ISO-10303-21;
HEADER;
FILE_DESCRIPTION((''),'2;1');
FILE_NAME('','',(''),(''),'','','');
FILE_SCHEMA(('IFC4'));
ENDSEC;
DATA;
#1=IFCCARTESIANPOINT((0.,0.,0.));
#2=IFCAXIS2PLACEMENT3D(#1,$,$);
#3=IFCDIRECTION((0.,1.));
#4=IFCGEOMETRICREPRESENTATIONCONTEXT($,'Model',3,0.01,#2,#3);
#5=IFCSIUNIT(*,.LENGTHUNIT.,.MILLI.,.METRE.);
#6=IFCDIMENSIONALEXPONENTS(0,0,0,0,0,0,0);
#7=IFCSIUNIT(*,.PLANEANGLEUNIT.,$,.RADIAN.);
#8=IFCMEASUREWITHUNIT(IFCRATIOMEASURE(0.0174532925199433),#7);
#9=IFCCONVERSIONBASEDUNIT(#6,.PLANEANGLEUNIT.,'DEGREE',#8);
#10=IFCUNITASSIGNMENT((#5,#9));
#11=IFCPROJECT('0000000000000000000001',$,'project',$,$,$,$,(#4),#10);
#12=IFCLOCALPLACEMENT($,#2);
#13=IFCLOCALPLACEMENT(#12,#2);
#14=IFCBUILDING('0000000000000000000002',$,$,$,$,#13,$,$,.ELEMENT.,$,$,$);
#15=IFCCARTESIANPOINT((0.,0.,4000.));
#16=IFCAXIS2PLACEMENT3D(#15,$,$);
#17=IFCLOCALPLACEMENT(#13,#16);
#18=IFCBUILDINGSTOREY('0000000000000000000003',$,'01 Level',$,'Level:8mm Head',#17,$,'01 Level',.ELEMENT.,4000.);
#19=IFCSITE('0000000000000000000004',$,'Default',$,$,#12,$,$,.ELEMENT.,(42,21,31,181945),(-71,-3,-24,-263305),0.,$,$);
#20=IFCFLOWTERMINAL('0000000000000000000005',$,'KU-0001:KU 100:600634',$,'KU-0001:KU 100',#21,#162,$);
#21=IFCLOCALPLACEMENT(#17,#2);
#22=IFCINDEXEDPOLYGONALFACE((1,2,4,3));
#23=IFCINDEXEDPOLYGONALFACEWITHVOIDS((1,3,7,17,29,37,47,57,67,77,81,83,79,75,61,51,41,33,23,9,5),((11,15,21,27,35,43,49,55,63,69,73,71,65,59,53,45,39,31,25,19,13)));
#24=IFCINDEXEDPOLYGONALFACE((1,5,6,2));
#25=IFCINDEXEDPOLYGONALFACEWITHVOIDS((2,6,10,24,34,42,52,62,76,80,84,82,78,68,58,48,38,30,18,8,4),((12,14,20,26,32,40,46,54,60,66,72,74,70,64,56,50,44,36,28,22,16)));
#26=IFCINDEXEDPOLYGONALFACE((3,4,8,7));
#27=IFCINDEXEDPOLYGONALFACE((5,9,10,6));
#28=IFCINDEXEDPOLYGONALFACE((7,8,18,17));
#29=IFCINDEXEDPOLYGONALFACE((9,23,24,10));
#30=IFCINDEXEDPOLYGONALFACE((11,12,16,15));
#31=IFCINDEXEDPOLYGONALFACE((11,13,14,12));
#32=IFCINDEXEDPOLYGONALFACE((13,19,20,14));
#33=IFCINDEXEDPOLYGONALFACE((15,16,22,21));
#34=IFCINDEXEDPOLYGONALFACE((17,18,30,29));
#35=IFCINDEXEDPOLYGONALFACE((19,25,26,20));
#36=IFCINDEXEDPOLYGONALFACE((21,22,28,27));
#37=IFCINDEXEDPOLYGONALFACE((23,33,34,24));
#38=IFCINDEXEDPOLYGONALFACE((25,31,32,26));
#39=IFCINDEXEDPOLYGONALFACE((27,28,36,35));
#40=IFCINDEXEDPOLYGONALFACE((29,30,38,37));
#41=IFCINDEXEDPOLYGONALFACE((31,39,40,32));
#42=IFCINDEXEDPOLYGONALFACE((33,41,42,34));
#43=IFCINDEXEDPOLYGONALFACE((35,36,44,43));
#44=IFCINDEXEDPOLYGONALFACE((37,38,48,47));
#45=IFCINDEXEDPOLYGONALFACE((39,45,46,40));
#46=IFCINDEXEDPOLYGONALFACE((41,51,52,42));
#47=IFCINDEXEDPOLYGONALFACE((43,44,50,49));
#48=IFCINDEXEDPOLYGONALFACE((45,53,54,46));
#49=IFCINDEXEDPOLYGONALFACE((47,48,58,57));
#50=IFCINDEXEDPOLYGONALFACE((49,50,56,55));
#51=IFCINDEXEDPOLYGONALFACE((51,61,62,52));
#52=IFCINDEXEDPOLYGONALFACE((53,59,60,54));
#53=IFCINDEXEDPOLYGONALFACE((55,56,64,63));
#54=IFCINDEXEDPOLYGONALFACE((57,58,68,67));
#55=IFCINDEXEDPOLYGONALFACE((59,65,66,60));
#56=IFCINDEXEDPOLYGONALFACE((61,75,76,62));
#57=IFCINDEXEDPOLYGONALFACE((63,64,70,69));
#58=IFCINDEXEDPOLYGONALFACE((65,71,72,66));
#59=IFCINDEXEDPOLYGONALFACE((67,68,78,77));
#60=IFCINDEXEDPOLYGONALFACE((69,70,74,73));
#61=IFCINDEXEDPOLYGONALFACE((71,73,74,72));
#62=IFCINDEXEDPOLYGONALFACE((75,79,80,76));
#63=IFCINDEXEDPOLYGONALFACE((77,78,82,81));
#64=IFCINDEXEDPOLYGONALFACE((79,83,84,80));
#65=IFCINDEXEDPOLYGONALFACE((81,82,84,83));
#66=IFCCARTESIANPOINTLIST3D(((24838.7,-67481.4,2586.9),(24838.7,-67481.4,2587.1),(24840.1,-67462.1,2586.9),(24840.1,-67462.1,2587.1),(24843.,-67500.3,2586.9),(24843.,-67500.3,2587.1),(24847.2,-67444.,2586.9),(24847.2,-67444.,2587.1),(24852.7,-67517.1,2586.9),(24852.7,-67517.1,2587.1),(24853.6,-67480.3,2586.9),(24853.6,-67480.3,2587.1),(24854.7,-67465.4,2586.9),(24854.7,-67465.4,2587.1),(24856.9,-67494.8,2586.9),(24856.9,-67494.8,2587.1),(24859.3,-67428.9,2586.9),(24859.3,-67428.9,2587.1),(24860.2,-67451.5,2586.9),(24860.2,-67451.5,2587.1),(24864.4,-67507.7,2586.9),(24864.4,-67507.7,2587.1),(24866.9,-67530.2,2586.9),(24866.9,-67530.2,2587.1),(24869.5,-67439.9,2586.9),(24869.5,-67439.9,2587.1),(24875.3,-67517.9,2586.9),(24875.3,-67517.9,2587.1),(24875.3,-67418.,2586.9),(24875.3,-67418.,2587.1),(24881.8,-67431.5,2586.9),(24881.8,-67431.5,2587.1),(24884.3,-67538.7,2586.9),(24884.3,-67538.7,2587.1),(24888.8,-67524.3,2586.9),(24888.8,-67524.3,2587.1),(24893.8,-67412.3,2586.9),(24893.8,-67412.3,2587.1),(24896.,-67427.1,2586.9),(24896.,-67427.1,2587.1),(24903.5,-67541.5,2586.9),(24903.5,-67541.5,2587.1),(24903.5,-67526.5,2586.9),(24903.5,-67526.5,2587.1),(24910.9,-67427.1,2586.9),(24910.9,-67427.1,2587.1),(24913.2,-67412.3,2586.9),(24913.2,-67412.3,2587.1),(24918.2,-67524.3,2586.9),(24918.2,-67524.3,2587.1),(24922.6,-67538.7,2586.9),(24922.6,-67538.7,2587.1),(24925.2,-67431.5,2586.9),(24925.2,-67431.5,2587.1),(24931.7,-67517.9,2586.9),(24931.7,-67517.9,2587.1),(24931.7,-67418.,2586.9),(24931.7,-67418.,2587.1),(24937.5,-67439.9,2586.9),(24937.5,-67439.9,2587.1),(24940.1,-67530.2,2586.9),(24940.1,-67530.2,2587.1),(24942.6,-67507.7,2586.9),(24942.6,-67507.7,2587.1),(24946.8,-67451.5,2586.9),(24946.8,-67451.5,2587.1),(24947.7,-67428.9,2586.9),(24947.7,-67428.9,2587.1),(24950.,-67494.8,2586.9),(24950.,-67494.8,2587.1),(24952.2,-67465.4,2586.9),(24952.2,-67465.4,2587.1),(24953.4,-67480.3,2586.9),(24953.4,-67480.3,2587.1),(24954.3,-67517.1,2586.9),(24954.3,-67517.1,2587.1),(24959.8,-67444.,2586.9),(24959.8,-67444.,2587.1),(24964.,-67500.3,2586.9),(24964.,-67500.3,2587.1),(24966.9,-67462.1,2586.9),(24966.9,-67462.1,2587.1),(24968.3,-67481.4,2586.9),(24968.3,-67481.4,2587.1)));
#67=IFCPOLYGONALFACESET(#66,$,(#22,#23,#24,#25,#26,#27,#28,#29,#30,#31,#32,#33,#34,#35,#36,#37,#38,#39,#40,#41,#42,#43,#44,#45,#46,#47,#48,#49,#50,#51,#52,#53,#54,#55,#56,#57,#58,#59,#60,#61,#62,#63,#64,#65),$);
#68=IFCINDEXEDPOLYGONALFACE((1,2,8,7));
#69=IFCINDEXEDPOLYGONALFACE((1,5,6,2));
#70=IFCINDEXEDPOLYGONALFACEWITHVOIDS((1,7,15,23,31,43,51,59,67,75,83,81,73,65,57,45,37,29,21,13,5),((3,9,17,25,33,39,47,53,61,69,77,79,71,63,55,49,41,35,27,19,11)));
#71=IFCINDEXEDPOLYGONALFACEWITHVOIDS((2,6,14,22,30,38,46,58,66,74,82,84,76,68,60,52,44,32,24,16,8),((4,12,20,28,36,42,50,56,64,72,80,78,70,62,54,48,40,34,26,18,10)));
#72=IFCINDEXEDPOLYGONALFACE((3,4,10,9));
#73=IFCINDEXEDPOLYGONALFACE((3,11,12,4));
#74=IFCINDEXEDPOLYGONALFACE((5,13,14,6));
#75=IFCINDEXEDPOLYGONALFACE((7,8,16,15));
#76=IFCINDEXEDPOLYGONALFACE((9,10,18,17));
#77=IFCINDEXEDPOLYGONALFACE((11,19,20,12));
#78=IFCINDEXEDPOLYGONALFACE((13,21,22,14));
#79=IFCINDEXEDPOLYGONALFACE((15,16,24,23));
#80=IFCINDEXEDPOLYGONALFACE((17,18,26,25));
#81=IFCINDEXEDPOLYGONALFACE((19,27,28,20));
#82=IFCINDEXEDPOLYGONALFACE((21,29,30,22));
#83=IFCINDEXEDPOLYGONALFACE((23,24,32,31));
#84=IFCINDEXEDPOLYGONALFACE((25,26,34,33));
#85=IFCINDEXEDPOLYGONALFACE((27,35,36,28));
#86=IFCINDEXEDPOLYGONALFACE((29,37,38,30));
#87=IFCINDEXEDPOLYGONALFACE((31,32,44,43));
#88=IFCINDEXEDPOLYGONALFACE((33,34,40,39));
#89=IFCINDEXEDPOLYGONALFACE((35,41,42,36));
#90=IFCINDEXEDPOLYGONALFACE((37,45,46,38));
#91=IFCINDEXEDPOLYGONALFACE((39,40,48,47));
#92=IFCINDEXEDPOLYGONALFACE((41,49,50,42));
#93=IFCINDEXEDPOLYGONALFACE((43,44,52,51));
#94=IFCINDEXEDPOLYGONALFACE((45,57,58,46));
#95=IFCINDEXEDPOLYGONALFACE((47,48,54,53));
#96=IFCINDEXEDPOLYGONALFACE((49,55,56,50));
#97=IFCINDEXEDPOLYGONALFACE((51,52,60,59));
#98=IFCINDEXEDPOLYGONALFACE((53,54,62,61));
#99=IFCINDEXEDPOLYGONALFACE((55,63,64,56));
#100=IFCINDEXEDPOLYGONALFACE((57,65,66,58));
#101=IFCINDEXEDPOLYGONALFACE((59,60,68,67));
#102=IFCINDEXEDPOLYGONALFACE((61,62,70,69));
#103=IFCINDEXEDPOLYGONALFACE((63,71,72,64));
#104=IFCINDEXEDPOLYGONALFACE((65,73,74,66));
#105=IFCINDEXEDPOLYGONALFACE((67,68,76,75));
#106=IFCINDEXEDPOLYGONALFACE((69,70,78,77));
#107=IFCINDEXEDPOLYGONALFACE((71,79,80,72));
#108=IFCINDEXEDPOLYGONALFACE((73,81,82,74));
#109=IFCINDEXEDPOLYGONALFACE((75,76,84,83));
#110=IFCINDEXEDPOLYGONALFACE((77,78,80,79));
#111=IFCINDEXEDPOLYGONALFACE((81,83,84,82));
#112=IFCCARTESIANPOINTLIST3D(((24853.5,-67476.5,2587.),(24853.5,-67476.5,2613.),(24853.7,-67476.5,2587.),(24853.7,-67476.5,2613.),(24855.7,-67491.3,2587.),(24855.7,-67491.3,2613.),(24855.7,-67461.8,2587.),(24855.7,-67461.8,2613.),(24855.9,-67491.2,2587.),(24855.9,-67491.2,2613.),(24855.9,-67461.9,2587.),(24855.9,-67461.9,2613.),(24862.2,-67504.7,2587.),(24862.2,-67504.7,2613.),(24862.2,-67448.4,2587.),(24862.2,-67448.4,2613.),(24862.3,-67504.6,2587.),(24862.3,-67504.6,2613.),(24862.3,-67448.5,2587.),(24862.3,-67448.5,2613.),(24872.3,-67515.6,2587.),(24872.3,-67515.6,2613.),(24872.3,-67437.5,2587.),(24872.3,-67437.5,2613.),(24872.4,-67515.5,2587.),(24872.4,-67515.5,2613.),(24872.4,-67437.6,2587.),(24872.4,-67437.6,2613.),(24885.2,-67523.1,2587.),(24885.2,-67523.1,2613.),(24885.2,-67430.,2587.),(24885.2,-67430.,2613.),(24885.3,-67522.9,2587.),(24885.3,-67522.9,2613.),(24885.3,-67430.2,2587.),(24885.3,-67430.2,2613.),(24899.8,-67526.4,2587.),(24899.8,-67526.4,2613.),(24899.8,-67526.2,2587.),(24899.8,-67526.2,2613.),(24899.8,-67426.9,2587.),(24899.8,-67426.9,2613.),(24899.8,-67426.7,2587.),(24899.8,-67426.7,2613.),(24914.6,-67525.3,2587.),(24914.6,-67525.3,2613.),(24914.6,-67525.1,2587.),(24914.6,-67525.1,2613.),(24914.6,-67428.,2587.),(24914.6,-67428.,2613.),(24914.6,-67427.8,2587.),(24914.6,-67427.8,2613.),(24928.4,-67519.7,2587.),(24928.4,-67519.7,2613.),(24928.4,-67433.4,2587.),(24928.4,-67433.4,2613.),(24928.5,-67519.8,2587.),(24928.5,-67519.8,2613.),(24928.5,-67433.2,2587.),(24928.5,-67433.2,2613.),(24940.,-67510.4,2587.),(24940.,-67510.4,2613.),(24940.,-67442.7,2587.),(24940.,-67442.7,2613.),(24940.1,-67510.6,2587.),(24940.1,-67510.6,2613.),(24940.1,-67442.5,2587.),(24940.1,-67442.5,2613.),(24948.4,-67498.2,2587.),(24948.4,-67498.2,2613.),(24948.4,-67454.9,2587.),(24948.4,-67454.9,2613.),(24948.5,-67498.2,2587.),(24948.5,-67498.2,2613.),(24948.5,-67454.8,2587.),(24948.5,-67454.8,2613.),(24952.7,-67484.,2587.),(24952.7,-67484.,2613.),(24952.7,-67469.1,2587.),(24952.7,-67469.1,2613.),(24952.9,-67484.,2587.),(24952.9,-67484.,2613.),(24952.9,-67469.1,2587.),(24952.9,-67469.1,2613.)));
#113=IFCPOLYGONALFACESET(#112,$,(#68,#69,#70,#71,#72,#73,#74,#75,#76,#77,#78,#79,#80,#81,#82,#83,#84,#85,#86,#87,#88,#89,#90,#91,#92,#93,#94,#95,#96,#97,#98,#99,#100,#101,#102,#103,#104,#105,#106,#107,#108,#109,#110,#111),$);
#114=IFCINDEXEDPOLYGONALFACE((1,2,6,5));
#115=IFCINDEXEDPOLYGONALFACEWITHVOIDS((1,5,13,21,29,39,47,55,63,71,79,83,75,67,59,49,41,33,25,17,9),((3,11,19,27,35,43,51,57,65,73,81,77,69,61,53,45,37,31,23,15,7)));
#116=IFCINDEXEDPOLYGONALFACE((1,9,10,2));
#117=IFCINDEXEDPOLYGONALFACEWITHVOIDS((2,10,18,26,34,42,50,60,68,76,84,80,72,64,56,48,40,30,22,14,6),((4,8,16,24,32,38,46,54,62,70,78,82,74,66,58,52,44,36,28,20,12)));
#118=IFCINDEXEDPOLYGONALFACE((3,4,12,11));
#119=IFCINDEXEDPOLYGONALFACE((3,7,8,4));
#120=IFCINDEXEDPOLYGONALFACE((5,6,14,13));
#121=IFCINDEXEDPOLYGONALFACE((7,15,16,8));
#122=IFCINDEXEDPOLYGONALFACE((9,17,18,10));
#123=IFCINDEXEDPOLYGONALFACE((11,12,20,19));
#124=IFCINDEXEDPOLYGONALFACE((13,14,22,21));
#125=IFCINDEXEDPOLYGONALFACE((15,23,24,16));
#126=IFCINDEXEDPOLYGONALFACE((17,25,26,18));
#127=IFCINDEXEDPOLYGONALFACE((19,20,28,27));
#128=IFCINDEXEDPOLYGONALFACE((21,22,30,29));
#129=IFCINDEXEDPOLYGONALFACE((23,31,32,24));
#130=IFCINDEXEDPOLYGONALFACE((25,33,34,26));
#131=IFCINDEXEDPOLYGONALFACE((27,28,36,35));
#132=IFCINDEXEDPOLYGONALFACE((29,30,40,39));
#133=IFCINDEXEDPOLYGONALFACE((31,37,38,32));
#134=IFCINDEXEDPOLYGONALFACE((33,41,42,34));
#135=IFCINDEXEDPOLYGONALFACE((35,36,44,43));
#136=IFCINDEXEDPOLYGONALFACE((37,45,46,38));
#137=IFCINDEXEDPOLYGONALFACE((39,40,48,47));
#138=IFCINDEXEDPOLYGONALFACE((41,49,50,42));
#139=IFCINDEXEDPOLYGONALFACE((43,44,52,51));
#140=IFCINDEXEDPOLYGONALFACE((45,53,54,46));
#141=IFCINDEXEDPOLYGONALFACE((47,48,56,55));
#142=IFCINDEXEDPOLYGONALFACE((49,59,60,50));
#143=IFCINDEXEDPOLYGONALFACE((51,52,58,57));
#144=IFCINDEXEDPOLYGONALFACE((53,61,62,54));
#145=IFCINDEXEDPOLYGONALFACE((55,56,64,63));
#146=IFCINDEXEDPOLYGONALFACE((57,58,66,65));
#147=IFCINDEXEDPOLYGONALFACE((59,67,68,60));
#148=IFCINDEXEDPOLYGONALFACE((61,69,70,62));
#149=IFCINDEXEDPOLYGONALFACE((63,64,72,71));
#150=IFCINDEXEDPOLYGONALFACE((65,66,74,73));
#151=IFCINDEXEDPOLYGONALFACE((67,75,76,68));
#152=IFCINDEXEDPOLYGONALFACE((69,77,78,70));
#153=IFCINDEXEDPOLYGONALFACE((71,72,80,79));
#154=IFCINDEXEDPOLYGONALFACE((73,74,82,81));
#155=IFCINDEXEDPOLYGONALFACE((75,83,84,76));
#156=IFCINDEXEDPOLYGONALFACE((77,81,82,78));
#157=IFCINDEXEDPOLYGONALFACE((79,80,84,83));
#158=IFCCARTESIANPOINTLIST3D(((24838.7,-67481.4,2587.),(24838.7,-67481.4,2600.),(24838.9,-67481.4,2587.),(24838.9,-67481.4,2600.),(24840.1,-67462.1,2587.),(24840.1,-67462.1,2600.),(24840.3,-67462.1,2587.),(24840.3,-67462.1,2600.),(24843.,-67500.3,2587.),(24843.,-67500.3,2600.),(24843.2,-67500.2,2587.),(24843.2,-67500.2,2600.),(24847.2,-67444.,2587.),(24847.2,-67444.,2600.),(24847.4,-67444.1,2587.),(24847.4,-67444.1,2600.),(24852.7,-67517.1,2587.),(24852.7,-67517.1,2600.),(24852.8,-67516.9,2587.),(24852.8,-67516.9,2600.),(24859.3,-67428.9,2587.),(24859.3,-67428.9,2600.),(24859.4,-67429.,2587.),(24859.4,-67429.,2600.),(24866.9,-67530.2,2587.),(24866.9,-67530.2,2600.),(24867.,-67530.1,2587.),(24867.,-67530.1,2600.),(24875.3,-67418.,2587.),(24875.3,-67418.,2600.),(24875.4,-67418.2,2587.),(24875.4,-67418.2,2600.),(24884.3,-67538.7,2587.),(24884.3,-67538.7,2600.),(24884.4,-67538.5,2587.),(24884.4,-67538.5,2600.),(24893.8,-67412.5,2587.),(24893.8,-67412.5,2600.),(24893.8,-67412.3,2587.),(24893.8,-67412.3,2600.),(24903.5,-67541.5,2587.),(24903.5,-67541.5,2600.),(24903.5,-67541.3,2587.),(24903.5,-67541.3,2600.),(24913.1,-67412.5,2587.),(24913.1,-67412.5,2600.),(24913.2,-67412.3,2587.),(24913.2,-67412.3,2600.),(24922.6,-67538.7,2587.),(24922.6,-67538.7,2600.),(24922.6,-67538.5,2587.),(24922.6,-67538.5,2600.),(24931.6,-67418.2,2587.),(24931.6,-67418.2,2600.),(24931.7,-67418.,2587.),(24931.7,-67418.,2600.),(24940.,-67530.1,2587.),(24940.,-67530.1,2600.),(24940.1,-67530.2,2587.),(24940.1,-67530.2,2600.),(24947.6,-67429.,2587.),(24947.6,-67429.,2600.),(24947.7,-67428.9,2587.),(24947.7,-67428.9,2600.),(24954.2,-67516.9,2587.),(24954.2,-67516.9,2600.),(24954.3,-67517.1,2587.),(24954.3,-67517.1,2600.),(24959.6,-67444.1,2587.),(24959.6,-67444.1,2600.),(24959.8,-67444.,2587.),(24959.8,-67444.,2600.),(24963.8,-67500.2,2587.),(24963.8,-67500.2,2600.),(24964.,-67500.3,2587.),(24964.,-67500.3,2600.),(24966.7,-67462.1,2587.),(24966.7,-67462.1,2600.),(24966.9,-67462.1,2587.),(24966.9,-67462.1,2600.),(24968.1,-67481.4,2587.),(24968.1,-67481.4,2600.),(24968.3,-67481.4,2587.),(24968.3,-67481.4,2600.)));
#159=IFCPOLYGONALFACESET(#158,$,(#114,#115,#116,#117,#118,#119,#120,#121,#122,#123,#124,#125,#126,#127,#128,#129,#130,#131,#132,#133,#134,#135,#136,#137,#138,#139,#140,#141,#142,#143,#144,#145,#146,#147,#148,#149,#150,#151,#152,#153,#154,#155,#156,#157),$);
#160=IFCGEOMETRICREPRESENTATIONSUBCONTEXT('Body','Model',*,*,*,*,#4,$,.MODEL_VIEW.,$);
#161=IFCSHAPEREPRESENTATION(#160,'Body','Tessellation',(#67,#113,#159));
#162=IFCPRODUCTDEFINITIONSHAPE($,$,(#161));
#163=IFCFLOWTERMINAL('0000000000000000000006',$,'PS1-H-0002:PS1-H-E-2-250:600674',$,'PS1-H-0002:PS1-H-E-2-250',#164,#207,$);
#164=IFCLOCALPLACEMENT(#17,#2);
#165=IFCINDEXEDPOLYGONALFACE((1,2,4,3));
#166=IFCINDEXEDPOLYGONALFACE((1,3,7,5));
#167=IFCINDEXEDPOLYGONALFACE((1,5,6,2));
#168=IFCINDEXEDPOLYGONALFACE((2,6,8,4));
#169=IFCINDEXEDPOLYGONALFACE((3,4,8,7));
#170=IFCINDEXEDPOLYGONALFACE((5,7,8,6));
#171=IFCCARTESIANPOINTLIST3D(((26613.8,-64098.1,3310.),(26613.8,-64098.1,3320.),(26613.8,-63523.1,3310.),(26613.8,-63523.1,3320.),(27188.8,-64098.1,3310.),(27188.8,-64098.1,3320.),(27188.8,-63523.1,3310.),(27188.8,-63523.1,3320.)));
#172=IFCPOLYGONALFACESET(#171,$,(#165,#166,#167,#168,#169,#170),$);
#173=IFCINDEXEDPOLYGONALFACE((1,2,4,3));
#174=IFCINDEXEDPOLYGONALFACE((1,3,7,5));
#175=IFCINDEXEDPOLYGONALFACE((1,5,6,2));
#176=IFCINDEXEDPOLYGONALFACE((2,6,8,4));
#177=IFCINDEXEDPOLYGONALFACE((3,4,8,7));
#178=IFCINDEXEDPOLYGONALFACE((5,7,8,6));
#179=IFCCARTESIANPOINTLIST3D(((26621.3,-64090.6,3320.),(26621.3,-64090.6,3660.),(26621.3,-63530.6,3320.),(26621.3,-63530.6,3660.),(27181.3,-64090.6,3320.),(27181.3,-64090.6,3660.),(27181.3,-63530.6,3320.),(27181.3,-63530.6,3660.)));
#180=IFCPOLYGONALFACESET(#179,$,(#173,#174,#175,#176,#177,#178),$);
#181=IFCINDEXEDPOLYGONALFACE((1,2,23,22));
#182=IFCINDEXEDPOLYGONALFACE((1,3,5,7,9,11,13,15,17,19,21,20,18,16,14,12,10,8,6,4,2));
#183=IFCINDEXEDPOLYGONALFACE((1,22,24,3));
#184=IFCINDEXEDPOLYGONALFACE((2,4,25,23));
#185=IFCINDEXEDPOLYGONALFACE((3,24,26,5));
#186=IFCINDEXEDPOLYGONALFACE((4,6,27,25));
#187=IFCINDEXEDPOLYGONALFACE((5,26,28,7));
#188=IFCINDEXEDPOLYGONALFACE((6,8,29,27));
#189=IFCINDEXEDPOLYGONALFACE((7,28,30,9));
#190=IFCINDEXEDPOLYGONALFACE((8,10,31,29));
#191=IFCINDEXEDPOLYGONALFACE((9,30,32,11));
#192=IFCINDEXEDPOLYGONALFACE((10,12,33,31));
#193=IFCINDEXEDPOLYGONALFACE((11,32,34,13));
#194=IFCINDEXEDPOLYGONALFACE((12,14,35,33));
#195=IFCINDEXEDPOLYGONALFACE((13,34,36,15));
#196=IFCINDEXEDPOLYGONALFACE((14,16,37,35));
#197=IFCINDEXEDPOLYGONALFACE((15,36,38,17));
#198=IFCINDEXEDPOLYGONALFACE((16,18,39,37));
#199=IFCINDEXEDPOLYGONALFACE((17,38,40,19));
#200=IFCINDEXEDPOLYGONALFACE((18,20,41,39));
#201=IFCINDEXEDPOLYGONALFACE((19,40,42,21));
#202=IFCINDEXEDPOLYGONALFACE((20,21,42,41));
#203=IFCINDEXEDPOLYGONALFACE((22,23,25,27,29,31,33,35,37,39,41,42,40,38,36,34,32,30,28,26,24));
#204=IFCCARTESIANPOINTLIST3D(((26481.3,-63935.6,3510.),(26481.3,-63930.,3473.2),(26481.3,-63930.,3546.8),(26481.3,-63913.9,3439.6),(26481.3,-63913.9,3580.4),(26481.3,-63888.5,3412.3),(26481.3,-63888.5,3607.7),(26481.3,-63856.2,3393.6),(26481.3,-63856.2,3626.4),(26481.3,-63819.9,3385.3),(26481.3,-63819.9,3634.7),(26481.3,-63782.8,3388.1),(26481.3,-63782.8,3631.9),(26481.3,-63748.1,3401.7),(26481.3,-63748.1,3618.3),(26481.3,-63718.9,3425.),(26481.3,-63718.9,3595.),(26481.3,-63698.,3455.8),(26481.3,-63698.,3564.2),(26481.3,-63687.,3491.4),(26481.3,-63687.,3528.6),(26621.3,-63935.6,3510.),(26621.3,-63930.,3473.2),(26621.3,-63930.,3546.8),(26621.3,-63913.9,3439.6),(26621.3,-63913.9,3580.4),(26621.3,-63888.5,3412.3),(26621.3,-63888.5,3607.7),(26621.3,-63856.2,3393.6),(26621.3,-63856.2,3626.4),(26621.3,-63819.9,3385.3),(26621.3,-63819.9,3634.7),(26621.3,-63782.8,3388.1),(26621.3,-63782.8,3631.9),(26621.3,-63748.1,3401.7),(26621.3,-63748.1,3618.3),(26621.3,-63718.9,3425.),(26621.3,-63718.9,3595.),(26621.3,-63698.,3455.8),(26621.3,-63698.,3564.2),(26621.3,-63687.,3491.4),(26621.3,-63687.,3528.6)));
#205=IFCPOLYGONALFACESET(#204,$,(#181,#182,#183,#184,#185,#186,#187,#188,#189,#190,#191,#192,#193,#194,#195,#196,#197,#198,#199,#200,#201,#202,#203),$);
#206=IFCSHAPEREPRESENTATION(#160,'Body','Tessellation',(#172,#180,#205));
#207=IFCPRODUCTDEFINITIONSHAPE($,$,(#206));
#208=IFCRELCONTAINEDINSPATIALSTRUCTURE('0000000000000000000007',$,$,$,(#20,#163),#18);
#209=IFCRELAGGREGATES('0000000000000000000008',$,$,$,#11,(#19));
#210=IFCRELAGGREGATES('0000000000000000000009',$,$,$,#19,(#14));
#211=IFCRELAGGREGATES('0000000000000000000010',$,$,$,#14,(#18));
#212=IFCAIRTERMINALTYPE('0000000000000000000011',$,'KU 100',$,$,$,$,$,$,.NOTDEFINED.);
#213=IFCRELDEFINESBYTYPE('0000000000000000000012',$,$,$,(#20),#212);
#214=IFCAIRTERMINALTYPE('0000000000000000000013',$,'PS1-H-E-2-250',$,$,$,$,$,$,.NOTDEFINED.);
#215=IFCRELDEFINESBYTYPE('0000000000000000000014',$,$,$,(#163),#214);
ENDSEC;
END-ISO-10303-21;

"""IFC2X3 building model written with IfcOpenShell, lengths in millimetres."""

from ifc_helpers import new_model, entity, si_unit, converted_unit, direction, frame, frame_2d, origin, origin_2d_with_axis, place, context, subcontext, project, spatial, rectangle, circle, hollow_circle, extrude, source, transform, mapped, type_object, type_shapes, element, save


model = new_model("IFC2X3")

# Units and contexts
model_context = context("Model", 3, precision=0.01, world=origin(), true_north=direction((0.0, 1.0)))
body_context = subcontext(model_context, "Body", "Model", "MODEL_VIEW")
ifc_project = project(units=[si_unit("LENGTHUNIT", "METRE", prefix="MILLI"), converted_unit("PLANEANGLEUNIT", "DEGREE", entity("IfcRatioMeasure", 0.0174532925199433), si_unit("PLANEANGLEUNIT", "RADIAN"), dimensions=[0, 0, 0, 0, 0, 0, 0])], contexts=[model_context])

# Site, building, storey
site_placement = place(None, origin())
site = spatial("IfcSite", under=ifc_project, at=site_placement, Name="Default", CompositionType="ELEMENT", RefLatitude=(42, 21, 31, 181945), RefLongitude=(-71, -3, -24, -263305), RefElevation=0.0)
building_placement = place(site_placement, origin())
building = spatial("IfcBuilding", under=site, at=building_placement, CompositionType="ELEMENT")
storey_placement = place(building_placement, frame((0.0, 0.0, 4000.0)))
storey = spatial("IfcBuildingStorey", under=building, at=storey_placement, Name="01 Level", ObjectType="Level:8mm Head", LongName="01 Level", CompositionType="ELEMENT", Elevation=4000.0)

# Flow terminals
air_terminal_type_1 = type_object("IfcAirTerminalType", Name="KU 100", PredefinedType="NOTDEFINED")
shared_shape_1 = source(origin(), body_context, "Body", "SweptSolid", [
    extrude(hollow_circle(Radius=65.0, WallThickness=15.0, at=frame_2d((0.0, 0.0), x_axis=(1.0, 0.0))), frame((12.9, 0.0, 0.0), z_axis=(1.0, 0.0, 0.0), x_axis=(0.0, -1.0, 0.0)), (0.0, 0.0, 1.0), 0.2),
    extrude(hollow_circle(Radius=50.0, WallThickness=0.2, at=frame_2d((0.0, 0.0), x_axis=(1.0, 0.0))), frame((-13.0, 0.0, 0.0), z_axis=(1.0, 0.0, 0.0), x_axis=(0.0, 0.0, -1.0)), (0.0, 0.0, 1.0), 26.0),
    extrude(hollow_circle(Radius=65.0, WallThickness=0.2, at=frame_2d((0.0, 0.0), x_axis=(1.0, 0.0))), frame((0.0, 0.0, 0.0), z_axis=(1.0, 0.0, 0.0), x_axis=(0.0, -1.0, 0.0)), (0.0, 0.0, 1.0), 13.0),
])
type_shapes(air_terminal_type_1, [shared_shape_1])
flow_terminal_1_placement = place(storey_placement, frame((24903.5, -67476.5, 2600.0), z_axis=(1.0, 0.0, 0.0), x_axis=(0.0, 0.0, -1.0)))
element("IfcFlowTerminal", 1, at=flow_terminal_1_placement, inside=storey, type_object=air_terminal_type_1, Name="KU-0001:KU 100:600634", ObjectType="KU-0001:KU 100", context=body_context, shape_type="MappedRepresentation", body=[
    mapped(shared_shape_1, transform((0.0, 0.0, 0.0), scale=1.0)),
])
air_terminal_type_2 = type_object("IfcAirTerminalType", Name="PS1-H-E-2-250", PredefinedType="NOTDEFINED")
shared_shape_2 = source(origin(), body_context, "Body", "SweptSolid", [
    extrude(rectangle(XDim=575.0, YDim=575.0, at=origin_2d_with_axis()), frame((0.0, 0.0, -10.0), z_axis=(0.0, 0.0, 1.0), x_axis=(0.0, 1.0, 0.0)), (0.0, 0.0, 1.0), 10.0),
    extrude(rectangle(XDim=560.0, YDim=560.0, at=origin_2d_with_axis()), frame((0.0, 0.0, 0.0), z_axis=(0.0, 0.0, 1.0), x_axis=(0.0, 1.0, 0.0)), (0.0, 0.0, 1.0), 340.0),
    extrude(circle(Radius=125.0, at=frame_2d((0.0, 0.0), x_axis=(1.0, 0.0))), frame((-420.0, 0.0, 190.0), z_axis=(1.0, 0.0, 0.0), x_axis=(0.0, -1.0, 0.0)), (0.0, 0.0, 1.0), 140.0),
])
type_shapes(air_terminal_type_2, [shared_shape_2])
flow_terminal_2_placement = place(storey_placement, frame((26901.3, -63810.6, 3320.0)))
element("IfcFlowTerminal", 2, at=flow_terminal_2_placement, inside=storey, type_object=air_terminal_type_2, Name="PS1-H-0002:PS1-H-E-2-250:600674", ObjectType="PS1-H-0002:PS1-H-E-2-250", context=body_context, shape_type="MappedRepresentation", body=[
    mapped(shared_shape_2, transform((0.0, 0.0, 0.0), scale=1.0)),
])

save(model, "model.ifc")
